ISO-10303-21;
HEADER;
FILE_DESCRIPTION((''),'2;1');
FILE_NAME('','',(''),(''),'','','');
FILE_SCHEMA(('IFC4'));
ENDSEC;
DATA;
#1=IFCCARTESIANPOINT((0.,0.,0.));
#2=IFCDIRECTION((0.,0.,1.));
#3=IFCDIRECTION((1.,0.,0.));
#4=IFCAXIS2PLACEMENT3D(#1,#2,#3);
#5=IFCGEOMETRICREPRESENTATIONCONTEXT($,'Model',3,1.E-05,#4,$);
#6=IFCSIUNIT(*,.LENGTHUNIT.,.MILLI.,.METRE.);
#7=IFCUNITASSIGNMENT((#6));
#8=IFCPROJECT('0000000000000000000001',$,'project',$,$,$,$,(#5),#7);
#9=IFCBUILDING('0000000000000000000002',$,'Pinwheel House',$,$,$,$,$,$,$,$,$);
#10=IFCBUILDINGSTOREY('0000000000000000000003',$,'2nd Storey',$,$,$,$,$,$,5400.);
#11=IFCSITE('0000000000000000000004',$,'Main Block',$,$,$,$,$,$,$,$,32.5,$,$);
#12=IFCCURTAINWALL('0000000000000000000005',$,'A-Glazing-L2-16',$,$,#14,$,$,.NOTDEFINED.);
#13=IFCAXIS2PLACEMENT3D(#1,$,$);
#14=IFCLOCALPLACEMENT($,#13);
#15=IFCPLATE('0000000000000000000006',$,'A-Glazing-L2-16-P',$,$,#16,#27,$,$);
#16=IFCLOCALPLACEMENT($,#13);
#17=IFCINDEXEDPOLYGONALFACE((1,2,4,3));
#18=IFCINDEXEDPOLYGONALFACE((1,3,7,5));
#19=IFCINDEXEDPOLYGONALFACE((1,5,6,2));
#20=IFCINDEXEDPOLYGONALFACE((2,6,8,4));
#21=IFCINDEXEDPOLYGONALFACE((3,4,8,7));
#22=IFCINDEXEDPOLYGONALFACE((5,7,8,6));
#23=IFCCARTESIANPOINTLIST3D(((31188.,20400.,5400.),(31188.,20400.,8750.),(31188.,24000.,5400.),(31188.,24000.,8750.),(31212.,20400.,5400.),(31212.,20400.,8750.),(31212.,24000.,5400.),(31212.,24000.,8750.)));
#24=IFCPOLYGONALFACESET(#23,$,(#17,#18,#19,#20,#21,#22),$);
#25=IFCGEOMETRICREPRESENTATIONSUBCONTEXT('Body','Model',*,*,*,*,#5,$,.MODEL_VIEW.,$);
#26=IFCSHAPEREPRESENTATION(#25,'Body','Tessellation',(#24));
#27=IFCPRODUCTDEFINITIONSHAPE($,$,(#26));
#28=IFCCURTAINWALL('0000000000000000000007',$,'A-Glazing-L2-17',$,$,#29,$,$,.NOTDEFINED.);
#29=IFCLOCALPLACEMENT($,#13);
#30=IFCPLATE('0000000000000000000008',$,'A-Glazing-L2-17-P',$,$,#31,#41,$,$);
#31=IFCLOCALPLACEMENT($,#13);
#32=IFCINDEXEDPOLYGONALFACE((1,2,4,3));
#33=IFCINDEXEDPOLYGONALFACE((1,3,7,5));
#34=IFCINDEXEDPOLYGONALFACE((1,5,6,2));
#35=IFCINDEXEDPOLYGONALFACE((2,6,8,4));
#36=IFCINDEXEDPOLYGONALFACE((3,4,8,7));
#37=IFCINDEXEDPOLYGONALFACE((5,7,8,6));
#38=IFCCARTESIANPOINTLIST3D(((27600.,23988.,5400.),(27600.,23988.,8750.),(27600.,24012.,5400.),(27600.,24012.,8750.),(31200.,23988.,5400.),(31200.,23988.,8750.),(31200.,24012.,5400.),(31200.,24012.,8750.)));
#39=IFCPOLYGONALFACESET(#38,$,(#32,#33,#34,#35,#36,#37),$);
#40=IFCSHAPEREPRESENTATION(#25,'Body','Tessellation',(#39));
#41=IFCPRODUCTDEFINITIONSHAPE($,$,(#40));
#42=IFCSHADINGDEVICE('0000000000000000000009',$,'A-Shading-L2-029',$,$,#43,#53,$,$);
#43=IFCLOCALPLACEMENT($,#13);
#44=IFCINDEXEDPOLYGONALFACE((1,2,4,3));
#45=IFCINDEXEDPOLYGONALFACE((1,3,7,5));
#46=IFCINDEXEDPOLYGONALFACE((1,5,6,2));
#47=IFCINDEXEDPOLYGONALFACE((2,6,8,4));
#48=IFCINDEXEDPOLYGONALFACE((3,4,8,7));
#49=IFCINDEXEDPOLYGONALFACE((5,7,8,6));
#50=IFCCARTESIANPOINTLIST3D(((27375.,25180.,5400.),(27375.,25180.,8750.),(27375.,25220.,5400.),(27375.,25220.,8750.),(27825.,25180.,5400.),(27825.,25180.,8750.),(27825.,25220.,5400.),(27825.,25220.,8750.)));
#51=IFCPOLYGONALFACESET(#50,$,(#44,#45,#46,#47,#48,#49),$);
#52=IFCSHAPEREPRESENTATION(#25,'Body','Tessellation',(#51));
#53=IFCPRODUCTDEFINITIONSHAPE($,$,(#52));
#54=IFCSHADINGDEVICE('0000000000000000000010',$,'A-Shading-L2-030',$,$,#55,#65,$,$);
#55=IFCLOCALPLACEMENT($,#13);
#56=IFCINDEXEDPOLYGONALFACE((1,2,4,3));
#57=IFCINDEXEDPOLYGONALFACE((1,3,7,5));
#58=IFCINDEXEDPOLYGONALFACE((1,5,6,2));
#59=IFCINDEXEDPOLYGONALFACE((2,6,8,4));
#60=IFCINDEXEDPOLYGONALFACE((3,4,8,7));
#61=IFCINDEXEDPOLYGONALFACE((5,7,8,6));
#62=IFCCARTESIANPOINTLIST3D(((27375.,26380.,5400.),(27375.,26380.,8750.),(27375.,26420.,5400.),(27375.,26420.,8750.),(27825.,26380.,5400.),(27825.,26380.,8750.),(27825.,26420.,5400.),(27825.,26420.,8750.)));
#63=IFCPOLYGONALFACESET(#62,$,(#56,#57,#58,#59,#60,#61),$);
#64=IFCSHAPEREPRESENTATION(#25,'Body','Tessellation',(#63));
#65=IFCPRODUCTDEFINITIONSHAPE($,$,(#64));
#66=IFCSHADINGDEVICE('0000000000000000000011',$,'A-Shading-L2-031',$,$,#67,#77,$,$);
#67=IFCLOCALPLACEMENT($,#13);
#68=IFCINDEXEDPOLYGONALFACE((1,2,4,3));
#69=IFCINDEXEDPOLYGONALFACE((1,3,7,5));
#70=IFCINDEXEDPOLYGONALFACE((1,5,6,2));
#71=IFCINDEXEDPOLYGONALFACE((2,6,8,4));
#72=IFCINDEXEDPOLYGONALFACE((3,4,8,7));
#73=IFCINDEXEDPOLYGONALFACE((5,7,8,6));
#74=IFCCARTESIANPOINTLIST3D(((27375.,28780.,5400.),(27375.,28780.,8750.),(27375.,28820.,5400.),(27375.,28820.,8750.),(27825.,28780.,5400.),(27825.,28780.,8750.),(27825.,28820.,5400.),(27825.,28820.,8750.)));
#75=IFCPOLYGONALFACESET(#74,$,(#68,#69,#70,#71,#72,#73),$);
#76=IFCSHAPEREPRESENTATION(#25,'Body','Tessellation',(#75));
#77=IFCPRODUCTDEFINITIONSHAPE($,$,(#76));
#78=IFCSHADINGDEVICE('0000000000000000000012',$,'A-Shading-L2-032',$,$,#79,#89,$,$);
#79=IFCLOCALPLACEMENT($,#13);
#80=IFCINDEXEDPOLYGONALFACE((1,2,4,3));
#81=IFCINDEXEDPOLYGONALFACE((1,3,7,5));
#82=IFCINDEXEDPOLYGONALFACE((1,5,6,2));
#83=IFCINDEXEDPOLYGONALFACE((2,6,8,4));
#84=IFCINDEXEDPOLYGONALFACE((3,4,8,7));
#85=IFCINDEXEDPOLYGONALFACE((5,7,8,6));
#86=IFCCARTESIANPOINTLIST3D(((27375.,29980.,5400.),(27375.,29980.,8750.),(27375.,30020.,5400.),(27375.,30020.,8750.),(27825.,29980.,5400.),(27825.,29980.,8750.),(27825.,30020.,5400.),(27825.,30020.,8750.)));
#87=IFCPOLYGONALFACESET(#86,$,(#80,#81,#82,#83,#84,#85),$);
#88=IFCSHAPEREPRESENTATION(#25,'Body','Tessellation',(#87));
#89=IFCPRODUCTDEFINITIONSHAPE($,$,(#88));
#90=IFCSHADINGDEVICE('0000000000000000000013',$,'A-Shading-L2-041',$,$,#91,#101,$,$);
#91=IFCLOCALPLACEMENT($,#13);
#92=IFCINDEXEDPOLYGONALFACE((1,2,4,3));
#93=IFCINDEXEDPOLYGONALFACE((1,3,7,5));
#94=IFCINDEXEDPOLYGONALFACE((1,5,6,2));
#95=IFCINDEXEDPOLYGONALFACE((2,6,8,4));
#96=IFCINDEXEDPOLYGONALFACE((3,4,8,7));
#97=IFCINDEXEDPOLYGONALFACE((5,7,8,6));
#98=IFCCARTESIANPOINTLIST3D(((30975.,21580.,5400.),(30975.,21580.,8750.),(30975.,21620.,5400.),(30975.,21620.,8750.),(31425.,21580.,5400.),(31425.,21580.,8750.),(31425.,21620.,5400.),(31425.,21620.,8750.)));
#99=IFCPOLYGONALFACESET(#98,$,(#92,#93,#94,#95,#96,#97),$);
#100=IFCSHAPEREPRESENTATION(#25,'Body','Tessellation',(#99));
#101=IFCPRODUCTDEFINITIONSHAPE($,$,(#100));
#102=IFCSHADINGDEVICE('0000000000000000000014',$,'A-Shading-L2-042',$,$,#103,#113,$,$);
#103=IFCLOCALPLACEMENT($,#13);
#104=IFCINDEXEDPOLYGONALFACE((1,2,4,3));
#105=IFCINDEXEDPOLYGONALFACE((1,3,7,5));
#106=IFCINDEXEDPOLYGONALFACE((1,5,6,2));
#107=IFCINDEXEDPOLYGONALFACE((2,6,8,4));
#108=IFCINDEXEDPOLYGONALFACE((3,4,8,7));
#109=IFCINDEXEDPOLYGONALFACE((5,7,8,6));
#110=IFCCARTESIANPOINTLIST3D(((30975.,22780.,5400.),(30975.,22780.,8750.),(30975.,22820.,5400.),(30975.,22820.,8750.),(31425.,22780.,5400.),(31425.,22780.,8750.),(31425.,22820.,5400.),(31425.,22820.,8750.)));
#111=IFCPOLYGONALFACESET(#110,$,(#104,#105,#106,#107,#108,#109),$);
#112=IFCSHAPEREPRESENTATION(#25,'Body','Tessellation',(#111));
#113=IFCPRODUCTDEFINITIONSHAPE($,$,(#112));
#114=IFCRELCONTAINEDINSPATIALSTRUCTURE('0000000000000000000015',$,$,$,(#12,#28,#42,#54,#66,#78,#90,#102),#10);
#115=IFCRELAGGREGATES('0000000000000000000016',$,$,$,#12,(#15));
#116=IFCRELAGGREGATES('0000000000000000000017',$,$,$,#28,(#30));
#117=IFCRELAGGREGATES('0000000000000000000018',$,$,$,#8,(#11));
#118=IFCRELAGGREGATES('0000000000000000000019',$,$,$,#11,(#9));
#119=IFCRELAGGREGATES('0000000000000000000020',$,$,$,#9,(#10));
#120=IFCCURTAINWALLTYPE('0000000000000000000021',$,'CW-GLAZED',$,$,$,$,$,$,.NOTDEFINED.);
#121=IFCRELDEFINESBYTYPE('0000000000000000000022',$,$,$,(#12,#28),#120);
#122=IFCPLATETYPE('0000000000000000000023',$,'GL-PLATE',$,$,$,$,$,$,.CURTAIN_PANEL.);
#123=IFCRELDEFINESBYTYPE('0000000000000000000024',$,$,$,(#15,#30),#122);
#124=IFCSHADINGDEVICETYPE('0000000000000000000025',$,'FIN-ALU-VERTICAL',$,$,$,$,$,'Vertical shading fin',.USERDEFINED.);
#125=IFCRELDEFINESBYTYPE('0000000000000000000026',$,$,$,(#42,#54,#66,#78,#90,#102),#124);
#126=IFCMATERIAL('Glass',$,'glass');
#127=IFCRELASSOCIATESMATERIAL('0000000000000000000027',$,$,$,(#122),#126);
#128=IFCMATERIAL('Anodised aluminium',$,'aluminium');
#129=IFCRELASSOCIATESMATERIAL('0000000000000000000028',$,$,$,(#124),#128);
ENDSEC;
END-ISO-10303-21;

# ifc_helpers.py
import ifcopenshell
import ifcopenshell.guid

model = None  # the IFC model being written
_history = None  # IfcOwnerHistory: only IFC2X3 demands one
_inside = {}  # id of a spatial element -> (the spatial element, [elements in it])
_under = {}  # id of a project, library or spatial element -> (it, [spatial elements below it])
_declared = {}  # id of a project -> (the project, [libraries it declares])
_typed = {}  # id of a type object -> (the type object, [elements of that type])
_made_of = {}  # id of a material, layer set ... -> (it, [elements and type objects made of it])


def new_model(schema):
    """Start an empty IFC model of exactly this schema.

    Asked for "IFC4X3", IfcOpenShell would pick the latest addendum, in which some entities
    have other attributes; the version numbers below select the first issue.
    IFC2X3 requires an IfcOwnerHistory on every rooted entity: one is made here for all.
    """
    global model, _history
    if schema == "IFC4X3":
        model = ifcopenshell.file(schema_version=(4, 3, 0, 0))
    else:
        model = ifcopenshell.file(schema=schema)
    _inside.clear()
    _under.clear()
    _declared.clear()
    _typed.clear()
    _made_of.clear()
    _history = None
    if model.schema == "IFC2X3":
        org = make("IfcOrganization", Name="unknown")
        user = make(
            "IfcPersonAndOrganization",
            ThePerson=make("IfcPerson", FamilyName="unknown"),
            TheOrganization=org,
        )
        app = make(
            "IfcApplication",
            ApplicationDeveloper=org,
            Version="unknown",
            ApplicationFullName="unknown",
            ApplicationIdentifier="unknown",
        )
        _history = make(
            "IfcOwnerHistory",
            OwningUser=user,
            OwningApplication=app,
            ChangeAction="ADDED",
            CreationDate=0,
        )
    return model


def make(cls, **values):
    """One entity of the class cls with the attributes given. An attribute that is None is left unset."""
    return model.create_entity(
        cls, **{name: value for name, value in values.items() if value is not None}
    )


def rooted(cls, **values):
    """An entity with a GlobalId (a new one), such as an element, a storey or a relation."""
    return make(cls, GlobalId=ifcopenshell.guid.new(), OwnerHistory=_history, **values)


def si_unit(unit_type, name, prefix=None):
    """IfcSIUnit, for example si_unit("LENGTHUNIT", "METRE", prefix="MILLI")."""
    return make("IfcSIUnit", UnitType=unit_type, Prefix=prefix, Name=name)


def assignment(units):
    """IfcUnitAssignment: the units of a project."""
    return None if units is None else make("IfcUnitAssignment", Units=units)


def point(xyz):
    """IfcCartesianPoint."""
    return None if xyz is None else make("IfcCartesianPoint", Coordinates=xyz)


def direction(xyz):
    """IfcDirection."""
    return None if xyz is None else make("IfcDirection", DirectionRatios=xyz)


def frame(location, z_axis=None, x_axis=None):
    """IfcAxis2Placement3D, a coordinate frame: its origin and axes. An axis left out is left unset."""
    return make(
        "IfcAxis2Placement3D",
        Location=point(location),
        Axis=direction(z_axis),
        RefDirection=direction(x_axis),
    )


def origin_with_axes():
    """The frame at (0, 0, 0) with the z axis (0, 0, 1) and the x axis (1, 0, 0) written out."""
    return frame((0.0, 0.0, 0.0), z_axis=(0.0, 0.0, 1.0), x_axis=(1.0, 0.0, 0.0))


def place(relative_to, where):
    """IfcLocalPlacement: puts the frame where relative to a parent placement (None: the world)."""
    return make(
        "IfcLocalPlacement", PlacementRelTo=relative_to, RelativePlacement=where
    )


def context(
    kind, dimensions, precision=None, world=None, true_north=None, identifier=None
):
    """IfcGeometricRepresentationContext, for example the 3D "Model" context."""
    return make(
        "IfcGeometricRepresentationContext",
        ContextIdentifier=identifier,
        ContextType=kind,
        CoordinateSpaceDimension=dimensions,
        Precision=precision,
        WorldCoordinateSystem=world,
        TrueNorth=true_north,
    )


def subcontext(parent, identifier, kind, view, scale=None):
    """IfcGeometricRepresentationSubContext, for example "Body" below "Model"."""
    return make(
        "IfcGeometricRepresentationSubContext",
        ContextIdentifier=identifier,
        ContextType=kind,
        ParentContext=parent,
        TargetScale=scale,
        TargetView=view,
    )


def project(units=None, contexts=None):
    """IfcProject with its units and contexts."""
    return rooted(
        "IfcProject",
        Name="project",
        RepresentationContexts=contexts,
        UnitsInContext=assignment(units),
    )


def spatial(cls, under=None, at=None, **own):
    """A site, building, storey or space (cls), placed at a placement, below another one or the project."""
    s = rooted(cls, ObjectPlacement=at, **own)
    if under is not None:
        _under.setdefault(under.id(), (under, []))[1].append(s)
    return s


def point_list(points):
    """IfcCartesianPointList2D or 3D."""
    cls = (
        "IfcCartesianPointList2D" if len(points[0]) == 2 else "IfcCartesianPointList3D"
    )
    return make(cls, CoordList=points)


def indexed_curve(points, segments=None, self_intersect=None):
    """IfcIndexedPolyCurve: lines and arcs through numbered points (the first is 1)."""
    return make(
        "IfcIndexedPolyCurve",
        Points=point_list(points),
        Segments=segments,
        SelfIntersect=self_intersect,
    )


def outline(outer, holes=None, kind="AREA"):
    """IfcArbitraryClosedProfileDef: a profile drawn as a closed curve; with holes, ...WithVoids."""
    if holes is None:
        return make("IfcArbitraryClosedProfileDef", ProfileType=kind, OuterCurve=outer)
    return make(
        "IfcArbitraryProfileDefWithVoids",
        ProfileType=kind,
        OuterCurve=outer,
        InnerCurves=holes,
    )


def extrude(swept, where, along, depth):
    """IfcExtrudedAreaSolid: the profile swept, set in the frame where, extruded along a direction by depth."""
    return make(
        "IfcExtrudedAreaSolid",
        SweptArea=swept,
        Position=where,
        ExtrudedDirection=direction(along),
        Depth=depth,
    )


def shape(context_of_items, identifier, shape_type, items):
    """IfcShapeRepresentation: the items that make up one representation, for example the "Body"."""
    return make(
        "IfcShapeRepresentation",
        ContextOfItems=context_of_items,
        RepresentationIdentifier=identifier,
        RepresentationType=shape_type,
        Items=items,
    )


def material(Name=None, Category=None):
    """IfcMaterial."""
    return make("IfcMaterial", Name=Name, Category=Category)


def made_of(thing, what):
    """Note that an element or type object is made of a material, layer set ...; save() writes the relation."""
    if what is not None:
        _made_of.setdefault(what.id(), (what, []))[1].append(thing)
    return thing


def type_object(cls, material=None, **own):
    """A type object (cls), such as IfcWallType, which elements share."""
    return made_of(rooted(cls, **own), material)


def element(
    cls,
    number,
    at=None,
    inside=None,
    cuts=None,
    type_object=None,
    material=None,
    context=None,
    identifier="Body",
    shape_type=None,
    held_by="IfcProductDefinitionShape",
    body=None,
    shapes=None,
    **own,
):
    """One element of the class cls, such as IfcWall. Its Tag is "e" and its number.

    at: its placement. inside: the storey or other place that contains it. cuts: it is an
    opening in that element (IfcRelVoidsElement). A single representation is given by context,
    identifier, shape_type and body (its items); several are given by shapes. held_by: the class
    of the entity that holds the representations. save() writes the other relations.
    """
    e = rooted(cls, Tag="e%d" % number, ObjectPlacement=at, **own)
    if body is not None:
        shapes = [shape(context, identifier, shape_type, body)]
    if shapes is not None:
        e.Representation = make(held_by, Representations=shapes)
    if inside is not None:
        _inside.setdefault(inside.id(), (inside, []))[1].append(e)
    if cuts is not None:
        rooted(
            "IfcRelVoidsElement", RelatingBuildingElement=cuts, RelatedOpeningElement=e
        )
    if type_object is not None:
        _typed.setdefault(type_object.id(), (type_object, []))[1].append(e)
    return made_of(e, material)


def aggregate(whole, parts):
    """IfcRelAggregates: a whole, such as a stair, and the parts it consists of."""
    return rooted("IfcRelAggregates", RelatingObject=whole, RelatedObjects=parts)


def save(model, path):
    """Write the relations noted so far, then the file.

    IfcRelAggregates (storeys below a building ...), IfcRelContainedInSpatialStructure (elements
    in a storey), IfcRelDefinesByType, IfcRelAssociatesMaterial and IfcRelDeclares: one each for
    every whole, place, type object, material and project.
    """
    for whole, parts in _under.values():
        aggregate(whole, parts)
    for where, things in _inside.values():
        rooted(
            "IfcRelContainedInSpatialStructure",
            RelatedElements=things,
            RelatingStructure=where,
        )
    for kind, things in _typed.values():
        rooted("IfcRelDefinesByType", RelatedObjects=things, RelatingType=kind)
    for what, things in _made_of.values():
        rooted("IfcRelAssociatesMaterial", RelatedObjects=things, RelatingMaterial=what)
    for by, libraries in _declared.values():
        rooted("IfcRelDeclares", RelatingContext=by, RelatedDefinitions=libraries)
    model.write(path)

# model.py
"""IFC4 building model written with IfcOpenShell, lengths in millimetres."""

from ifc_helpers import new_model, si_unit, frame, origin_with_axes, place, context, subcontext, project, spatial, indexed_curve, outline, extrude, material, type_object, element, aggregate, save


model = new_model("IFC4")

# Units and contexts
model_context = context("Model", 3, precision=1e-05, world=origin_with_axes())
body_context = subcontext(model_context, "Body", "Model", "MODEL_VIEW")
ifc_project = project(units=[si_unit("LENGTHUNIT", "METRE", prefix="MILLI")], contexts=[model_context])

# Site, building, storey
site = spatial("IfcSite", under=ifc_project, Name="Main Block", RefElevation=32.5)
building = spatial("IfcBuilding", under=site, Name="Pinwheel House")
storey = spatial("IfcBuildingStorey", under=building, Name="2nd Storey", Elevation=5400.0)

# Shared definitions
ifc_material_1 = material(Name="Anodised aluminium", Category="aluminium")

# Curtain walls, plates
curtain_wall_type = type_object("IfcCurtainWallType", Name="CW-GLAZED", PredefinedType="NOTDEFINED")
ifc_material_2 = material(Name="Glass", Category="glass")
plate_type = type_object("IfcPlateType", Name="GL-PLATE", PredefinedType="CURTAIN_PANEL", material=ifc_material_2)
curtain_wall_1 = element("IfcCurtainWall", 1, inside=storey, type_object=curtain_wall_type, Name="A-Glazing-L2-16", PredefinedType="NOTDEFINED")
plate_1_placement = place(None, frame((31200.0, 22200.0, 5400.0), z_axis=(0.0, 0.0, 1.0), x_axis=(0.0, 1.0, 0.0)))
plate_1 = element("IfcPlate", 2, at=plate_1_placement, type_object=plate_type, Name="A-Glazing-L2-16-P", context=body_context, shape_type="SweptSolid", body=[
    extrude(outline(indexed_curve([(-1800.0, -12.0), (1800.0, -12.0), (1800.0, 12.0), (-1800.0, 12.0)])), None, (0.0, 0.0, 1.0), 3350.0),
])
aggregate(curtain_wall_1, [plate_1])
curtain_wall_2 = element("IfcCurtainWall", 3, inside=storey, type_object=curtain_wall_type, Name="A-Glazing-L2-17", PredefinedType="NOTDEFINED")
plate_2_placement = place(None, frame((29400.0, 24000.0, 5400.0), z_axis=(0.0, 0.0, 1.0), x_axis=(-1.0, 0.0, 0.0)))
plate_2 = element("IfcPlate", 4, at=plate_2_placement, type_object=plate_type, Name="A-Glazing-L2-17-P", context=body_context, shape_type="SweptSolid", body=[
    extrude(outline(indexed_curve([(-1800.0, -12.0), (1800.0, -12.0), (1800.0, 12.0), (-1800.0, 12.0)])), None, (0.0, 0.0, 1.0), 3350.0),
])
aggregate(curtain_wall_2, [plate_2])

# Shading devices
shading_device_type = type_object("IfcShadingDeviceType", Name="FIN-ALU-VERTICAL", ElementType="Vertical shading fin", PredefinedType="USERDEFINED", material=ifc_material_1)
for number, where, z_axis, x_axis, name in (
    (5, (27600.0, 25200.0, 5400.0), (0.0, 0.0, 1.0), (0.0, 1.0, 0.0), "A-Shading-L2-029"),
    (6, (27600.0, 26400.0, 5400.0), (0.0, 0.0, 1.0), (0.0, 1.0, 0.0), "A-Shading-L2-030"),
    (7, (27600.0, 28800.0, 5400.0), (0.0, 0.0, 1.0), (0.0, 1.0, 0.0), "A-Shading-L2-031"),
    (8, (27600.0, 30000.0, 5400.0), (0.0, 0.0, 1.0), (0.0, 1.0, 0.0), "A-Shading-L2-032"),
    (9, (31200.0, 21600.0, 5400.0), (0.0, 0.0, 1.0), (0.0, 1.0, 0.0), "A-Shading-L2-041"),
    (10, (31200.0, 22800.0, 5400.0), (0.0, 0.0, 1.0), (0.0, 1.0, 0.0), "A-Shading-L2-042"),
):
    element("IfcShadingDevice", number, at=place(None, frame(where, z_axis=z_axis, x_axis=x_axis)), inside=storey, type_object=shading_device_type, Name=name, context=body_context, shape_type="SweptSolid", body=[
        extrude(outline(indexed_curve([(-20.0, -225.0), (20.0, -225.0), (20.0, 225.0), (-20.0, 225.0)])), None, (0.0, 0.0, 1.0), 3350.0),
    ])

save(model, "model.ifc")
